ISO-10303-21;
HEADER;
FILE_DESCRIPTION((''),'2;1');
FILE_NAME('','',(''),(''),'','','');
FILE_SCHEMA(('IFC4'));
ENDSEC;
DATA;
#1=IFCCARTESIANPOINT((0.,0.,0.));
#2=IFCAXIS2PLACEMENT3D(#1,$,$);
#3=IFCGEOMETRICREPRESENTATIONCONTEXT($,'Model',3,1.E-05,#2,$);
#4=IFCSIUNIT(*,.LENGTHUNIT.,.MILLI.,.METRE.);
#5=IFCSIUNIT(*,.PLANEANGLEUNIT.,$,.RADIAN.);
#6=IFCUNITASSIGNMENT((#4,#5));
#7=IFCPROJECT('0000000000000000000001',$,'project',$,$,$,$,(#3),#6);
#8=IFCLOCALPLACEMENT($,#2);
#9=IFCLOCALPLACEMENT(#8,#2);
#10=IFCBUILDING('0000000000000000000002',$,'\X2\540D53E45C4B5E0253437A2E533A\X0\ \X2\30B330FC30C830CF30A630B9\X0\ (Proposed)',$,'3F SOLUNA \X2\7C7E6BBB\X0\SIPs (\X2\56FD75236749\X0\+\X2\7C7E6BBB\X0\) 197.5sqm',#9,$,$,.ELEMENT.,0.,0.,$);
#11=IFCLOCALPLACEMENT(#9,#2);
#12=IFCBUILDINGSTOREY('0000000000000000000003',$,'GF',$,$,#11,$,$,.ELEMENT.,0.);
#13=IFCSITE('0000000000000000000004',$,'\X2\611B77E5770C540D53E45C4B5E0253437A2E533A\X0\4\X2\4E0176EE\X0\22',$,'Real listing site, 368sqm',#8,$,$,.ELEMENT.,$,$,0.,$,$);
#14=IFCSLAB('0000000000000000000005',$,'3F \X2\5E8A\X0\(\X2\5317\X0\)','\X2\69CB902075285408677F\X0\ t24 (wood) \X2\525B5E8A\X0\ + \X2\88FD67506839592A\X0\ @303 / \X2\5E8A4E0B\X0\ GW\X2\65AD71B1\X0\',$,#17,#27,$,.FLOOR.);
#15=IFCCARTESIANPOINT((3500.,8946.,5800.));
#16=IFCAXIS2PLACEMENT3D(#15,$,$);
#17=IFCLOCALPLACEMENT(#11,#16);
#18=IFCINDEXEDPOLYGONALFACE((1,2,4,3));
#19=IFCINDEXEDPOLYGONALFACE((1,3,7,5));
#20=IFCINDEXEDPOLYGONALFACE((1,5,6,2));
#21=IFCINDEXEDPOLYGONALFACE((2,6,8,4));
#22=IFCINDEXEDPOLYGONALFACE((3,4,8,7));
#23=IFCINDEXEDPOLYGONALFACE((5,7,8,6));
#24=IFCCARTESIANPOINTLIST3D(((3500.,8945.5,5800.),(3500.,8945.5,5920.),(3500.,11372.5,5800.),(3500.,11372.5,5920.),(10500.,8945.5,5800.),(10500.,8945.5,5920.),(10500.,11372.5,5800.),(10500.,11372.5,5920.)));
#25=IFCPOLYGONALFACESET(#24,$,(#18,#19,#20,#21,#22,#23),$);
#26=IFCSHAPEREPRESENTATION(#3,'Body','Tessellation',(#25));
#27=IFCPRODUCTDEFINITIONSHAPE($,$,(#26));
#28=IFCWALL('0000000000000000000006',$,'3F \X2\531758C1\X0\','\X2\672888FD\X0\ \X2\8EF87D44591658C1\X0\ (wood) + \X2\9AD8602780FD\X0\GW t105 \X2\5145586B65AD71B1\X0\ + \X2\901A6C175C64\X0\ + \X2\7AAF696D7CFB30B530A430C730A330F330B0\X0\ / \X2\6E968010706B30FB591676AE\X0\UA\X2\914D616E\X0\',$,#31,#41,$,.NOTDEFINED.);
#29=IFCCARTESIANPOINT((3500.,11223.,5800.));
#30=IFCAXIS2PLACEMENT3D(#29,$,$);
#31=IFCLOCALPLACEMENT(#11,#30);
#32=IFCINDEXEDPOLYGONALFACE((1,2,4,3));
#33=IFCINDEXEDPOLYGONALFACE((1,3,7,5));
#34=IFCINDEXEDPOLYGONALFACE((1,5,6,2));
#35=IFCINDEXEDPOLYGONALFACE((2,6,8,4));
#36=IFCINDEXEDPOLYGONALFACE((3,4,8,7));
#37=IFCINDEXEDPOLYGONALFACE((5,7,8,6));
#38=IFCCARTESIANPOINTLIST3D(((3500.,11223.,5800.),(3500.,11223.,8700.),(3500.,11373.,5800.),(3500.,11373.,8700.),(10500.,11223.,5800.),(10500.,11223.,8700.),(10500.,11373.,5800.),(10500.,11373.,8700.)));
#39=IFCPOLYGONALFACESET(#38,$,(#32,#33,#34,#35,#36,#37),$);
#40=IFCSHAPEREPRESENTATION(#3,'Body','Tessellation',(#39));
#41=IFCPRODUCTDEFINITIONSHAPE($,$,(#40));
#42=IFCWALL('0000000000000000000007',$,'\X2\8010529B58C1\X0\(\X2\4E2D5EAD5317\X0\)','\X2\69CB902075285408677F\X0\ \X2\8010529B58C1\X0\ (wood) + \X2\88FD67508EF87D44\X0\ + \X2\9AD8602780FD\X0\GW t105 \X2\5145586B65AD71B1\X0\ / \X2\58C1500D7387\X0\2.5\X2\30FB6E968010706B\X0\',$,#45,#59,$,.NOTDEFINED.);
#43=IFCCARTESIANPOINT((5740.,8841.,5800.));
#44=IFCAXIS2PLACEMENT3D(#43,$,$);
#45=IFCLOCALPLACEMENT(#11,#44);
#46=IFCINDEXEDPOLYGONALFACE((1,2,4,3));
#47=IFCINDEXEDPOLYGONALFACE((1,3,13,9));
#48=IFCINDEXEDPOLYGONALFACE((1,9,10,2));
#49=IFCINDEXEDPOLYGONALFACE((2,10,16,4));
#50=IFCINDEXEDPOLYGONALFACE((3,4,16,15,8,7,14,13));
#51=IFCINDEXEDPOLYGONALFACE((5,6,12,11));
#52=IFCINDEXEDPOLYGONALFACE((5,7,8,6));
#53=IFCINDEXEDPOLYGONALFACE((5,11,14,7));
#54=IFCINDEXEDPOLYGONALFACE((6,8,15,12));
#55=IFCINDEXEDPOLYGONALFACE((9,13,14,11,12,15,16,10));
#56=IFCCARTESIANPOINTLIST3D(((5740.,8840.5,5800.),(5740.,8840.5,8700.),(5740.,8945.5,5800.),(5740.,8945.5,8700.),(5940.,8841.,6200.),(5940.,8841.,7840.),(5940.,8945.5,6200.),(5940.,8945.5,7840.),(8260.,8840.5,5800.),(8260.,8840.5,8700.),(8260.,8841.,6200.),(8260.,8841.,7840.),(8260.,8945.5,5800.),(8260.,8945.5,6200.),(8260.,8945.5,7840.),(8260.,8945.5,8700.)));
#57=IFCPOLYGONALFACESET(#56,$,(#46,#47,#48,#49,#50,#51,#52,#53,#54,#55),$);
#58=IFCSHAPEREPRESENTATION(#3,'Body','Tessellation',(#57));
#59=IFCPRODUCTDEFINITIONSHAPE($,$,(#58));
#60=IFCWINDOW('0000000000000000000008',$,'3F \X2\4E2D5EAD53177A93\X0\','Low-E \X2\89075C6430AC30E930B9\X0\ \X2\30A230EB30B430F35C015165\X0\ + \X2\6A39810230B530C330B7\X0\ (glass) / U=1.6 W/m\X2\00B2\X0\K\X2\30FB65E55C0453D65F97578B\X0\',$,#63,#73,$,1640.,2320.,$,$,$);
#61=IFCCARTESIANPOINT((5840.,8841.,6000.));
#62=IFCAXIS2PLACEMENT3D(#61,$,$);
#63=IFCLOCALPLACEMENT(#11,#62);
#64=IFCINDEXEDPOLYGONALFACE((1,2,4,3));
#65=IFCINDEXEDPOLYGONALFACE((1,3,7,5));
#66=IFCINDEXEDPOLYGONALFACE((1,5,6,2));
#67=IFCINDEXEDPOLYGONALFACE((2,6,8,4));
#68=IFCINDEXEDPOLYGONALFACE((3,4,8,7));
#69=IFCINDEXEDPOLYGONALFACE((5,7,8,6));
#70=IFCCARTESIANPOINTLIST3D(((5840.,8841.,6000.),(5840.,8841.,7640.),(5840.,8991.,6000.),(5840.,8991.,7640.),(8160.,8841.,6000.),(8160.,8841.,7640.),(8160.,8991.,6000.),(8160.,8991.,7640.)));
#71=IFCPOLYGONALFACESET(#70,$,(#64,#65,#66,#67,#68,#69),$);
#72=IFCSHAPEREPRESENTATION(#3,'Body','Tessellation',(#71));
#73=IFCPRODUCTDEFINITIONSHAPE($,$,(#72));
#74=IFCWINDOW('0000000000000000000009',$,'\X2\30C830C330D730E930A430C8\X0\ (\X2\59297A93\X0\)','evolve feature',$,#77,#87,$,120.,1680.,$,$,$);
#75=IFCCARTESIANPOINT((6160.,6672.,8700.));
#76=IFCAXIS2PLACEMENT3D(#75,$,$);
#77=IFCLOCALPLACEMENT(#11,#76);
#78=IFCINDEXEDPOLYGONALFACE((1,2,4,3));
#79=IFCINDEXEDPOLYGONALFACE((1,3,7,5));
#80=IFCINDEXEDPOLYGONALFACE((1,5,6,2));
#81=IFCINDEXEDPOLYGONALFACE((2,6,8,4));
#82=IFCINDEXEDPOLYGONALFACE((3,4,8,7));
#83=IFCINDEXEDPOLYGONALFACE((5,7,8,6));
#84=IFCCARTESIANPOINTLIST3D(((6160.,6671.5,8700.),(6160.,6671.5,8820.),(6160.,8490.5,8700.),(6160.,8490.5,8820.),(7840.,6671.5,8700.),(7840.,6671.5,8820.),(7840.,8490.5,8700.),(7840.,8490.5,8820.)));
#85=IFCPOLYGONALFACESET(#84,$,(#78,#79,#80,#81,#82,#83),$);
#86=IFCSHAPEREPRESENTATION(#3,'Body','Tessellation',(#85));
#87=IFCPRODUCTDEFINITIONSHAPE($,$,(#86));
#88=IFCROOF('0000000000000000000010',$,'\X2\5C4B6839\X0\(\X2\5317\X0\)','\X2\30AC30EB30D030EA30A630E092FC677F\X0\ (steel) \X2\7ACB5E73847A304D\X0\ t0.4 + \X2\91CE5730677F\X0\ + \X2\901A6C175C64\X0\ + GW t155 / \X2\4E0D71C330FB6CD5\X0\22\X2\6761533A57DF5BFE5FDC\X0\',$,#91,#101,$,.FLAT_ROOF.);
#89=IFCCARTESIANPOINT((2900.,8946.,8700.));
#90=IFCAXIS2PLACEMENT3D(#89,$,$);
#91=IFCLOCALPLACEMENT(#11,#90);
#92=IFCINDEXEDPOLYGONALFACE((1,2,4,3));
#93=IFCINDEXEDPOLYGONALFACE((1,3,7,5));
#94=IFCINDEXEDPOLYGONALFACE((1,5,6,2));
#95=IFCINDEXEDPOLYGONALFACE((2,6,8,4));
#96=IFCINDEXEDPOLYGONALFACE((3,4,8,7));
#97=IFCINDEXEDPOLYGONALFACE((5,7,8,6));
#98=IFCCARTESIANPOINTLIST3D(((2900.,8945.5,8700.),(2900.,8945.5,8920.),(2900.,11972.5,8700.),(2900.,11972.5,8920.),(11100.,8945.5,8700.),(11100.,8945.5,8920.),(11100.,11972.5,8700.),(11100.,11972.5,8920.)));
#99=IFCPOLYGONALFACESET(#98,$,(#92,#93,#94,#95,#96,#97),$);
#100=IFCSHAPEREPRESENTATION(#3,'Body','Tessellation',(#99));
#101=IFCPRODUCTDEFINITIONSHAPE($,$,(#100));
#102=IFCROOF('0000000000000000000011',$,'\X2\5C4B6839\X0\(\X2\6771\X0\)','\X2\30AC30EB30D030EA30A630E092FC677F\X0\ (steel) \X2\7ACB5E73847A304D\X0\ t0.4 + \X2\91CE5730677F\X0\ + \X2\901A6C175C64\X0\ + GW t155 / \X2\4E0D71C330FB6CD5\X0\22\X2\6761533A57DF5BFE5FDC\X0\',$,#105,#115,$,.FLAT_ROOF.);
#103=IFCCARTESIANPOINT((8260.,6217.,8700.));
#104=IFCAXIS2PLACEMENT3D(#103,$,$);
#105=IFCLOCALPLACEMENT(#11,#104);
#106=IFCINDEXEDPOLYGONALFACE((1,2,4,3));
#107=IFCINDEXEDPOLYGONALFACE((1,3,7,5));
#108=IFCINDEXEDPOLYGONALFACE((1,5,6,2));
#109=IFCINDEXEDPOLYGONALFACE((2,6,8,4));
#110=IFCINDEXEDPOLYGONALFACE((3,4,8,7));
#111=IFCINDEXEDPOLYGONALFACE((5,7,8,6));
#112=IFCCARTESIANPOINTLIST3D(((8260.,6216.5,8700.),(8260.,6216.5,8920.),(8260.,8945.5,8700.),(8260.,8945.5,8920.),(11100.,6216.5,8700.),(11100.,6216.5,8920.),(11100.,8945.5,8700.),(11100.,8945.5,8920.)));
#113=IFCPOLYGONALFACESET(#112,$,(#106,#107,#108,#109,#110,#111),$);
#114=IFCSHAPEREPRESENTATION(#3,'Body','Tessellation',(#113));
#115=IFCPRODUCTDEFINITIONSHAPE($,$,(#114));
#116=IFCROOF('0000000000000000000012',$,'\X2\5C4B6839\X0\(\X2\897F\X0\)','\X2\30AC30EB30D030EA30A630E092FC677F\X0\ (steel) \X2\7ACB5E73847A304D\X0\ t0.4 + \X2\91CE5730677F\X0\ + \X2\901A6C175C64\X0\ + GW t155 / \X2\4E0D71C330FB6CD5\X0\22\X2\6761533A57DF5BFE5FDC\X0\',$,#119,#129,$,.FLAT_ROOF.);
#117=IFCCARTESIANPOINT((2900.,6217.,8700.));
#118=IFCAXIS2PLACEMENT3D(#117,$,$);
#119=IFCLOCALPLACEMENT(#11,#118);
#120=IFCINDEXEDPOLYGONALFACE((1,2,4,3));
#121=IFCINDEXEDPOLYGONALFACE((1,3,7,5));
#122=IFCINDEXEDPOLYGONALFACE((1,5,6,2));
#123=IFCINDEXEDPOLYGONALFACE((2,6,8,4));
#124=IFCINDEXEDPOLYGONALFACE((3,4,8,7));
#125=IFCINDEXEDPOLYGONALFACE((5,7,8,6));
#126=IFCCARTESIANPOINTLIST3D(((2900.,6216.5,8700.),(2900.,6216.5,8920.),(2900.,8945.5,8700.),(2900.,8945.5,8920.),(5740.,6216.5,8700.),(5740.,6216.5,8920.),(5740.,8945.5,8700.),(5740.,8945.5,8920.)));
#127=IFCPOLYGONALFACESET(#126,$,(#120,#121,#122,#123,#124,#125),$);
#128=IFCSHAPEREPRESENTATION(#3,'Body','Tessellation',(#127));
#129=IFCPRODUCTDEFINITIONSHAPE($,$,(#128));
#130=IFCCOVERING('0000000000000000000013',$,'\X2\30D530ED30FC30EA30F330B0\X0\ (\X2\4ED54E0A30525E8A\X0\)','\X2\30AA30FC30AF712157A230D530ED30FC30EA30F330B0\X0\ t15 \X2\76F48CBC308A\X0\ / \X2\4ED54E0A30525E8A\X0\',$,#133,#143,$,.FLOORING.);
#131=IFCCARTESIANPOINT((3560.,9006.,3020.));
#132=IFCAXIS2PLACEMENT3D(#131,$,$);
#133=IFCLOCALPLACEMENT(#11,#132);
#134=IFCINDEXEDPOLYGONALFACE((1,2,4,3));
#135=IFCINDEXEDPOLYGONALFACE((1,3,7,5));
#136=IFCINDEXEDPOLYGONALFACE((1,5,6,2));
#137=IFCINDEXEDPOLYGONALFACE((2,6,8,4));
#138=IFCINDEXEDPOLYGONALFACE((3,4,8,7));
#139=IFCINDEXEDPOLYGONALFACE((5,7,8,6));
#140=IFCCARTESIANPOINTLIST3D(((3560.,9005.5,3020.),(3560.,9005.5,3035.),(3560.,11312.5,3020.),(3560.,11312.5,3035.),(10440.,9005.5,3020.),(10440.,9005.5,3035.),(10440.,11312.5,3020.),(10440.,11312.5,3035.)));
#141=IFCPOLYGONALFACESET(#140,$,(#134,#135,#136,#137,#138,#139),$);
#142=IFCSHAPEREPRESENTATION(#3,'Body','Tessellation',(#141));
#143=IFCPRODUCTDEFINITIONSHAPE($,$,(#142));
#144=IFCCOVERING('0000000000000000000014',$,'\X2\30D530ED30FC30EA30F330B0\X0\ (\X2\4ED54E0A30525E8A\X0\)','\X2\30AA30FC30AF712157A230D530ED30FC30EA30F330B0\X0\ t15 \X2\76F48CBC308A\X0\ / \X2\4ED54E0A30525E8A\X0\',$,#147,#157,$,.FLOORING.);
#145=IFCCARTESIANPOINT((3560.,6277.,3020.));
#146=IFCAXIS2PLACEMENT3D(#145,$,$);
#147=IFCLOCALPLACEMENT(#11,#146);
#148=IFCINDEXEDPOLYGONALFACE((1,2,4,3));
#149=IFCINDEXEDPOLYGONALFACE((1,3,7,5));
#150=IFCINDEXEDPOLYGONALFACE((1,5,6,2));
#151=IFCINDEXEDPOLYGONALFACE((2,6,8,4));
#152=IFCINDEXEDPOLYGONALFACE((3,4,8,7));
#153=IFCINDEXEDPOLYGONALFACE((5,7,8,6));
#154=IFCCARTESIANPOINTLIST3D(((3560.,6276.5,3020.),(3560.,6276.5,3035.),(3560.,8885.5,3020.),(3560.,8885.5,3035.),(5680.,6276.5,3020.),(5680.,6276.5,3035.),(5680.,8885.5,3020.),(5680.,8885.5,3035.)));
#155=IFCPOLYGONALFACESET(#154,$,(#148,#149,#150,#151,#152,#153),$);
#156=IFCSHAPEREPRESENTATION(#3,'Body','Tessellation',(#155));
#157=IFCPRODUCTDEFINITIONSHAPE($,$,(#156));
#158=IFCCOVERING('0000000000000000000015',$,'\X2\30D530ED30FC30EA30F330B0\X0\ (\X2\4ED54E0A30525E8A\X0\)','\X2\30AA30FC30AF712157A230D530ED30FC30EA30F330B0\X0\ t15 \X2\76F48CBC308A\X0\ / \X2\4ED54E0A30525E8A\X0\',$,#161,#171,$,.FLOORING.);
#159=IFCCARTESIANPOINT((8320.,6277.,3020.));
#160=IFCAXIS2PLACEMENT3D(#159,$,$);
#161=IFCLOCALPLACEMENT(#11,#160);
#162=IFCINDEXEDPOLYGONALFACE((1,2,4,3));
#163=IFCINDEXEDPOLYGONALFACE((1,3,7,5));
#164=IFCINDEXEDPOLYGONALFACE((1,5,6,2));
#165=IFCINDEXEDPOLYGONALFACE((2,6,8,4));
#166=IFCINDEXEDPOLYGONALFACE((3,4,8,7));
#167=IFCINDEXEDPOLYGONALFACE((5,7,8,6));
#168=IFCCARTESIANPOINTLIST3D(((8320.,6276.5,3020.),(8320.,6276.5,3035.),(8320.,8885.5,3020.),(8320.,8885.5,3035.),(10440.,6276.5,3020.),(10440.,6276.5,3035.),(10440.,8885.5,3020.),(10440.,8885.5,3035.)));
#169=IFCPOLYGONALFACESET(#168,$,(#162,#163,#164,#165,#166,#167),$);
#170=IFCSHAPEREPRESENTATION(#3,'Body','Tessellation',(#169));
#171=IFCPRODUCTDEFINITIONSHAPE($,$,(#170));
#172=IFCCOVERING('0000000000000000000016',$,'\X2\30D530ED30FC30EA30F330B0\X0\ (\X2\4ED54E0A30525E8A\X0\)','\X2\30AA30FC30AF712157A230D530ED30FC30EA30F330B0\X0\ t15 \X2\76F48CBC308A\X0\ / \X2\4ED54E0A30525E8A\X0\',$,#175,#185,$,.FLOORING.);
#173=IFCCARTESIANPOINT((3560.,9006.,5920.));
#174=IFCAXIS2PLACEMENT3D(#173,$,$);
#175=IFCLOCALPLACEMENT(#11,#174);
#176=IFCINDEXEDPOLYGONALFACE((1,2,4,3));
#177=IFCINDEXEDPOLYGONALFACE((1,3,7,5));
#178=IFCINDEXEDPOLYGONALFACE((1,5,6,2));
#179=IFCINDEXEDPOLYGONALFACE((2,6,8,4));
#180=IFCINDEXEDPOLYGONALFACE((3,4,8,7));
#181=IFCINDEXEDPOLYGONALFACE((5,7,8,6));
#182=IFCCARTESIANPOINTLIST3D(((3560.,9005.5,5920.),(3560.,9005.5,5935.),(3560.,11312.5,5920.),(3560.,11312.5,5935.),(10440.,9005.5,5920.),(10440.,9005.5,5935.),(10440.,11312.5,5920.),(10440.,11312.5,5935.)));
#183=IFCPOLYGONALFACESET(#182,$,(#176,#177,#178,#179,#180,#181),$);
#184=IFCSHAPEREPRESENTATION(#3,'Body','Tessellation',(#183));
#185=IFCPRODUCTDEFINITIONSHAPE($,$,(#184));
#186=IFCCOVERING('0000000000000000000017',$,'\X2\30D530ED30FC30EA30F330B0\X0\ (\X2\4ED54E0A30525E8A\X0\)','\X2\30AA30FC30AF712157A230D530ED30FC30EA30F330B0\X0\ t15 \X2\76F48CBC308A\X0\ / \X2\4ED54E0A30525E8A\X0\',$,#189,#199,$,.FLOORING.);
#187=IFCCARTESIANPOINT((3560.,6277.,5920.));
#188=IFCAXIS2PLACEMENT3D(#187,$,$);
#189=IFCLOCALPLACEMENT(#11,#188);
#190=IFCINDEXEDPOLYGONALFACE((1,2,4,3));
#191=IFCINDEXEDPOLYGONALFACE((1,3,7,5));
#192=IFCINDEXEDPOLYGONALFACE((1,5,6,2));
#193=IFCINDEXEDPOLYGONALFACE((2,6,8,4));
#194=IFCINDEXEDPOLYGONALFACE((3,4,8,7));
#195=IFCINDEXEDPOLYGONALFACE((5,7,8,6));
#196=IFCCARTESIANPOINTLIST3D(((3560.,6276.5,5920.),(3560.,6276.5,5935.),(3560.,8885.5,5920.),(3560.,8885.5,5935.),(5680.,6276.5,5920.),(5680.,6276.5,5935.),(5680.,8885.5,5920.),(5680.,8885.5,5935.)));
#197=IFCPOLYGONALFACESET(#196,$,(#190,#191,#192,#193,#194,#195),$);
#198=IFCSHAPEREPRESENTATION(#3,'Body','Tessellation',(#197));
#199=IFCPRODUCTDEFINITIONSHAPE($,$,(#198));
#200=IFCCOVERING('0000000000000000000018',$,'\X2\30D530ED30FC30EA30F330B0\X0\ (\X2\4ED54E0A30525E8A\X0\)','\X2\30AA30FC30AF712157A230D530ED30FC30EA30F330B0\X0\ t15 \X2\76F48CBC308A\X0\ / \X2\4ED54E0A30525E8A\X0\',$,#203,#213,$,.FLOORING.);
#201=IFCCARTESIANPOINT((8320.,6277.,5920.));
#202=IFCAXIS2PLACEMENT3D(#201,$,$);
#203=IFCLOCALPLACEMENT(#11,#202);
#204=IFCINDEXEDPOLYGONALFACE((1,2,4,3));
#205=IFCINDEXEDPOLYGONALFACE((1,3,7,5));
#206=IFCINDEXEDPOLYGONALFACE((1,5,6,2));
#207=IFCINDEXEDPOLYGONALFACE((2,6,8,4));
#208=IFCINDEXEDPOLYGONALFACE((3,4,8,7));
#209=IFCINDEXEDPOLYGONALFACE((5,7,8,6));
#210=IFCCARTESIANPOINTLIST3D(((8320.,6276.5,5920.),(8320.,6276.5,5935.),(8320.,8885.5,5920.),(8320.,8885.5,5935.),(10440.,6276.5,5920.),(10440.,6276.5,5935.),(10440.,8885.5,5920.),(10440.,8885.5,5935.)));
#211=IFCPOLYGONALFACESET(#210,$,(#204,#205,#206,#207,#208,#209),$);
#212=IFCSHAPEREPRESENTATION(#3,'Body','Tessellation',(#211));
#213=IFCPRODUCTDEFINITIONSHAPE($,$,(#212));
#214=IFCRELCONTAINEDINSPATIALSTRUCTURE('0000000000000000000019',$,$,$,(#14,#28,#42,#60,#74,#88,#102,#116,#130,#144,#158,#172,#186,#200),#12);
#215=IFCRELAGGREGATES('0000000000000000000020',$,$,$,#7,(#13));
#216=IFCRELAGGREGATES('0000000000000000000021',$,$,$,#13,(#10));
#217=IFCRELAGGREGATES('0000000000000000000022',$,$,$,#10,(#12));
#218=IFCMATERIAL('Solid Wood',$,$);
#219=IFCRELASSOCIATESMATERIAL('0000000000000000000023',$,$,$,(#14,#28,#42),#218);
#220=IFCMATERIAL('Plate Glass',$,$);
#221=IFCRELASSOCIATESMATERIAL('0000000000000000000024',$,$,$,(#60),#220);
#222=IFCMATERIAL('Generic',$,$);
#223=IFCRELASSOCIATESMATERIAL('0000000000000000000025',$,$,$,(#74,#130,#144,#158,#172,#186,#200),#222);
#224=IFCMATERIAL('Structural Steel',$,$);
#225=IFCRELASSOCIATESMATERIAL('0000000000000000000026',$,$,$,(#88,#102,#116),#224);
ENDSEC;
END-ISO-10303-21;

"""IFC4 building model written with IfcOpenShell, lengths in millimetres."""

from ifc_helpers import new_model, si_unit, frame, frame_2d, origin, place, context, project, spatial, rectangle, extrude, material, element, fill, save


model = new_model("IFC4")

# Units and contexts
model_context = context("Model", 3, precision=1e-05, world=origin())
ifc_project = project(units=[si_unit("LENGTHUNIT", "METRE", prefix="MILLI"), si_unit("PLANEANGLEUNIT", "RADIAN")], contexts=[model_context])

# Site, building, storey
site_placement = place(None, origin())
site = spatial("IfcSite", under=ifc_project, at=site_placement, Name="愛知県名古屋市千種区4丁目22", ObjectType="Real listing site, 368sqm", CompositionType="ELEMENT", RefElevation=0.0)
building_placement = place(site_placement, origin())
building = spatial("IfcBuilding", under=site, at=building_placement, Name="名古屋市千種区 コートハウス (Proposed)", ObjectType="3F SOLUNA 籾殻SIPs (国産杉+籾殻) 197.5sqm", CompositionType="ELEMENT", ElevationOfRefHeight=0.0, ElevationOfTerrain=0.0)
storey_placement = place(building_placement, origin())
storey = spatial("IfcBuildingStorey", under=building, at=storey_placement, Name="GF", CompositionType="ELEMENT", Elevation=0.0)

# Slab
ifc_material_1 = material(Name="Solid Wood")
slab_placement = place(storey_placement, frame((3500.0, 8946.0, 5800.0)))
element("IfcSlab", 1, at=slab_placement, inside=storey, material=ifc_material_1, Name="3F 床(北)", Description="構造用合板 t24 (wood) 剛床 + 製材根太 @303 / 床下 GW断熱", PredefinedType="FLOOR", context=model_context, shape_type="SweptSolid", body=[
    extrude(rectangle(XDim=7000.0, YDim=2427.0, at=frame_2d((3500.0, 1213.0))), frame((3500.0, 8946.0, 5800.0)), (0.0, 0.0, 1.0), 120.0),
])

# Wall
wall_1_placement = place(storey_placement, frame((3500.0, 11223.0, 5800.0)))
element("IfcWall", 2, at=wall_1_placement, inside=storey, material=ifc_material_1, Name="3F 北壁", Description="木製 軸組外壁 (wood) + 高性能GW t105 充填断熱 + 通気層 + 窯業系サイディング / 準耐火・外皮UA配慮", PredefinedType="NOTDEFINED", context=model_context, shape_type="SweptSolid", body=[
    extrude(rectangle(XDim=7000.0, YDim=150.0, at=frame_2d((3500.0, 75.0))), frame((3500.0, 11223.0, 5800.0)), (0.0, 0.0, 1.0), 2900.0),
])

# Wall, opening, window
wall_2_placement = place(storey_placement, frame((5740.0, 8841.0, 5800.0)))
wall_2 = element("IfcWall", 3, at=wall_2_placement, inside=storey, material=ifc_material_1, Name="耐力壁(中庭北)", Description="構造用合板 耐力壁 (wood) + 製材軸組 + 高性能GW t105 充填断熱 / 壁倍率2.5・準耐火", PredefinedType="NOTDEFINED", context=model_context, shape_type="SweptSolid", body=[
    extrude(rectangle(XDim=2520.0, YDim=105.0, at=frame_2d((1260.0, 52.0))), frame((5740.0, 8841.0, 5800.0)), (0.0, 0.0, 1.0), 2900.0),
])
opening_placement = place(storey_placement, frame((5840.0, 8841.0, 6000.0)))
opening = element("IfcOpeningElement", 4, at=opening_placement, cuts=wall_2, PredefinedType="NOTDEFINED", context=model_context, shape_type="SweptSolid", body=[
    extrude(rectangle(XDim=2320.0, YDim=150.0, at=frame_2d((1160.0, 75.0))), frame((5840.0, 8841.0, 6000.0)), (0.0, 0.0, 1.0), 1640.0),
])
ifc_material_2 = material(Name="Plate Glass")
window_1_placement = place(storey_placement, frame((5840.0, 8841.0, 6000.0)))
window_1 = element("IfcWindow", 5, at=window_1_placement, inside=storey, material=ifc_material_2, Name="3F 中庭北窓", Description="Low-E 複層ガラス アルゴン封入 + 樹脂サッシ (glass) / U=1.6 W/m²K・日射取得型", OverallHeight=1640.0, OverallWidth=2320.0, context=model_context, shape_type="SweptSolid", body=[
    extrude(rectangle(XDim=2320.0, YDim=150.0, at=frame_2d((1160.0, 75.0))), frame((5840.0, 8841.0, 6000.0)), (0.0, 0.0, 1.0), 1640.0),
])
fill(opening, window_1)

# Window
ifc_material_3 = material(Name="Generic")
window_2_placement = place(storey_placement, frame((6160.0, 6672.0, 8700.0)))
element("IfcWindow", 6, at=window_2_placement, inside=storey, material=ifc_material_3, Name="トップライト (天窓)", Description="evolve feature", OverallHeight=120.0, OverallWidth=1680.0, context=model_context, shape_type="SweptSolid", body=[
    extrude(rectangle(XDim=1680.0, YDim=1819.0, at=frame_2d((840.0, 909.0))), frame((6160.0, 6672.0, 8700.0)), (0.0, 0.0, 1.0), 120.0),
])

# Roofs
ifc_material_4 = material(Name="Structural Steel")
roof_1_placement = place(storey_placement, frame((2900.0, 8946.0, 8700.0)))
element("IfcRoof", 7, at=roof_1_placement, inside=storey, material=ifc_material_4, Name="屋根(北)", Description="ガルバリウム鋼板 (steel) 立平葺き t0.4 + 野地板 + 通気層 + GW t155 / 不燃・法22条区域対応", PredefinedType="FLAT_ROOF", context=model_context, shape_type="SweptSolid", body=[
    extrude(rectangle(XDim=8200.0, YDim=3027.0, at=frame_2d((4100.0, 1513.0))), frame((2900.0, 8946.0, 8700.0)), (0.0, 0.0, 1.0), 220.0),
])
roof_2_placement = place(storey_placement, frame((8260.0, 6217.0, 8700.0)))
element("IfcRoof", 8, at=roof_2_placement, inside=storey, material=ifc_material_4, Name="屋根(東)", Description="ガルバリウム鋼板 (steel) 立平葺き t0.4 + 野地板 + 通気層 + GW t155 / 不燃・法22条区域対応", PredefinedType="FLAT_ROOF", context=model_context, shape_type="SweptSolid", body=[
    extrude(rectangle(XDim=2840.0, YDim=2729.0, at=frame_2d((1420.0, 1364.0))), frame((8260.0, 6217.0, 8700.0)), (0.0, 0.0, 1.0), 220.0),
])
roof_3_placement = place(storey_placement, frame((2900.0, 6217.0, 8700.0)))
element("IfcRoof", 9, at=roof_3_placement, inside=storey, material=ifc_material_4, Name="屋根(西)", Description="ガルバリウム鋼板 (steel) 立平葺き t0.4 + 野地板 + 通気層 + GW t155 / 不燃・法22条区域対応", PredefinedType="FLAT_ROOF", context=model_context, shape_type="SweptSolid", body=[
    extrude(rectangle(XDim=2840.0, YDim=2729.0, at=frame_2d((1420.0, 1364.0))), frame((2900.0, 6217.0, 8700.0)), (0.0, 0.0, 1.0), 220.0),
])

# Coverings
covering_1_placement = place(storey_placement, frame((3560.0, 9006.0, 3020.0)))
element("IfcCovering", 10, at=covering_1_placement, inside=storey, material=ifc_material_3, Name="フローリング (仕上げ床)", Description="オーク無垢フローリング t15 直貼り / 仕上げ床", PredefinedType="FLOORING", context=model_context, shape_type="SweptSolid", body=[
    extrude(rectangle(XDim=6880.0, YDim=2307.0, at=frame_2d((3440.0, 1153.0))), frame((3560.0, 9006.0, 3020.0)), (0.0, 0.0, 1.0), 15.0),
])
covering_2_placement = place(storey_placement, frame((3560.0, 6277.0, 3020.0)))
element("IfcCovering", 11, at=covering_2_placement, inside=storey, material=ifc_material_3, Name="フローリング (仕上げ床)", Description="オーク無垢フローリング t15 直貼り / 仕上げ床", PredefinedType="FLOORING", context=model_context, shape_type="SweptSolid", body=[
    extrude(rectangle(XDim=2120.0, YDim=2609.0, at=frame_2d((1060.0, 1304.0))), frame((3560.0, 6277.0, 3020.0)), (0.0, 0.0, 1.0), 15.0),
])
covering_3_placement = place(storey_placement, frame((8320.0, 6277.0, 3020.0)))
element("IfcCovering", 12, at=covering_3_placement, inside=storey, material=ifc_material_3, Name="フローリング (仕上げ床)", Description="オーク無垢フローリング t15 直貼り / 仕上げ床", PredefinedType="FLOORING", context=model_context, shape_type="SweptSolid", body=[
    extrude(rectangle(XDim=2120.0, YDim=2609.0, at=frame_2d((1060.0, 1304.0))), frame((8320.0, 6277.0, 3020.0)), (0.0, 0.0, 1.0), 15.0),
])
covering_4_placement = place(storey_placement, frame((3560.0, 9006.0, 5920.0)))
element("IfcCovering", 13, at=covering_4_placement, inside=storey, material=ifc_material_3, Name="フローリング (仕上げ床)", Description="オーク無垢フローリング t15 直貼り / 仕上げ床", PredefinedType="FLOORING", context=model_context, shape_type="SweptSolid", body=[
    extrude(rectangle(XDim=6880.0, YDim=2307.0, at=frame_2d((3440.0, 1153.0))), frame((3560.0, 9006.0, 5920.0)), (0.0, 0.0, 1.0), 15.0),
])
covering_5_placement = place(storey_placement, frame((3560.0, 6277.0, 5920.0)))
element("IfcCovering", 14, at=covering_5_placement, inside=storey, material=ifc_material_3, Name="フローリング (仕上げ床)", Description="オーク無垢フローリング t15 直貼り / 仕上げ床", PredefinedType="FLOORING", context=model_context, shape_type="SweptSolid", body=[
    extrude(rectangle(XDim=2120.0, YDim=2609.0, at=frame_2d((1060.0, 1304.0))), frame((3560.0, 6277.0, 5920.0)), (0.0, 0.0, 1.0), 15.0),
])
covering_6_placement = place(storey_placement, frame((8320.0, 6277.0, 5920.0)))
element("IfcCovering", 15, at=covering_6_placement, inside=storey, material=ifc_material_3, Name="フローリング (仕上げ床)", Description="オーク無垢フローリング t15 直貼り / 仕上げ床", PredefinedType="FLOORING", context=model_context, shape_type="SweptSolid", body=[
    extrude(rectangle(XDim=2120.0, YDim=2609.0, at=frame_2d((1060.0, 1304.0))), frame((8320.0, 6277.0, 5920.0)), (0.0, 0.0, 1.0), 15.0),
])

save(model, "model.ifc")
